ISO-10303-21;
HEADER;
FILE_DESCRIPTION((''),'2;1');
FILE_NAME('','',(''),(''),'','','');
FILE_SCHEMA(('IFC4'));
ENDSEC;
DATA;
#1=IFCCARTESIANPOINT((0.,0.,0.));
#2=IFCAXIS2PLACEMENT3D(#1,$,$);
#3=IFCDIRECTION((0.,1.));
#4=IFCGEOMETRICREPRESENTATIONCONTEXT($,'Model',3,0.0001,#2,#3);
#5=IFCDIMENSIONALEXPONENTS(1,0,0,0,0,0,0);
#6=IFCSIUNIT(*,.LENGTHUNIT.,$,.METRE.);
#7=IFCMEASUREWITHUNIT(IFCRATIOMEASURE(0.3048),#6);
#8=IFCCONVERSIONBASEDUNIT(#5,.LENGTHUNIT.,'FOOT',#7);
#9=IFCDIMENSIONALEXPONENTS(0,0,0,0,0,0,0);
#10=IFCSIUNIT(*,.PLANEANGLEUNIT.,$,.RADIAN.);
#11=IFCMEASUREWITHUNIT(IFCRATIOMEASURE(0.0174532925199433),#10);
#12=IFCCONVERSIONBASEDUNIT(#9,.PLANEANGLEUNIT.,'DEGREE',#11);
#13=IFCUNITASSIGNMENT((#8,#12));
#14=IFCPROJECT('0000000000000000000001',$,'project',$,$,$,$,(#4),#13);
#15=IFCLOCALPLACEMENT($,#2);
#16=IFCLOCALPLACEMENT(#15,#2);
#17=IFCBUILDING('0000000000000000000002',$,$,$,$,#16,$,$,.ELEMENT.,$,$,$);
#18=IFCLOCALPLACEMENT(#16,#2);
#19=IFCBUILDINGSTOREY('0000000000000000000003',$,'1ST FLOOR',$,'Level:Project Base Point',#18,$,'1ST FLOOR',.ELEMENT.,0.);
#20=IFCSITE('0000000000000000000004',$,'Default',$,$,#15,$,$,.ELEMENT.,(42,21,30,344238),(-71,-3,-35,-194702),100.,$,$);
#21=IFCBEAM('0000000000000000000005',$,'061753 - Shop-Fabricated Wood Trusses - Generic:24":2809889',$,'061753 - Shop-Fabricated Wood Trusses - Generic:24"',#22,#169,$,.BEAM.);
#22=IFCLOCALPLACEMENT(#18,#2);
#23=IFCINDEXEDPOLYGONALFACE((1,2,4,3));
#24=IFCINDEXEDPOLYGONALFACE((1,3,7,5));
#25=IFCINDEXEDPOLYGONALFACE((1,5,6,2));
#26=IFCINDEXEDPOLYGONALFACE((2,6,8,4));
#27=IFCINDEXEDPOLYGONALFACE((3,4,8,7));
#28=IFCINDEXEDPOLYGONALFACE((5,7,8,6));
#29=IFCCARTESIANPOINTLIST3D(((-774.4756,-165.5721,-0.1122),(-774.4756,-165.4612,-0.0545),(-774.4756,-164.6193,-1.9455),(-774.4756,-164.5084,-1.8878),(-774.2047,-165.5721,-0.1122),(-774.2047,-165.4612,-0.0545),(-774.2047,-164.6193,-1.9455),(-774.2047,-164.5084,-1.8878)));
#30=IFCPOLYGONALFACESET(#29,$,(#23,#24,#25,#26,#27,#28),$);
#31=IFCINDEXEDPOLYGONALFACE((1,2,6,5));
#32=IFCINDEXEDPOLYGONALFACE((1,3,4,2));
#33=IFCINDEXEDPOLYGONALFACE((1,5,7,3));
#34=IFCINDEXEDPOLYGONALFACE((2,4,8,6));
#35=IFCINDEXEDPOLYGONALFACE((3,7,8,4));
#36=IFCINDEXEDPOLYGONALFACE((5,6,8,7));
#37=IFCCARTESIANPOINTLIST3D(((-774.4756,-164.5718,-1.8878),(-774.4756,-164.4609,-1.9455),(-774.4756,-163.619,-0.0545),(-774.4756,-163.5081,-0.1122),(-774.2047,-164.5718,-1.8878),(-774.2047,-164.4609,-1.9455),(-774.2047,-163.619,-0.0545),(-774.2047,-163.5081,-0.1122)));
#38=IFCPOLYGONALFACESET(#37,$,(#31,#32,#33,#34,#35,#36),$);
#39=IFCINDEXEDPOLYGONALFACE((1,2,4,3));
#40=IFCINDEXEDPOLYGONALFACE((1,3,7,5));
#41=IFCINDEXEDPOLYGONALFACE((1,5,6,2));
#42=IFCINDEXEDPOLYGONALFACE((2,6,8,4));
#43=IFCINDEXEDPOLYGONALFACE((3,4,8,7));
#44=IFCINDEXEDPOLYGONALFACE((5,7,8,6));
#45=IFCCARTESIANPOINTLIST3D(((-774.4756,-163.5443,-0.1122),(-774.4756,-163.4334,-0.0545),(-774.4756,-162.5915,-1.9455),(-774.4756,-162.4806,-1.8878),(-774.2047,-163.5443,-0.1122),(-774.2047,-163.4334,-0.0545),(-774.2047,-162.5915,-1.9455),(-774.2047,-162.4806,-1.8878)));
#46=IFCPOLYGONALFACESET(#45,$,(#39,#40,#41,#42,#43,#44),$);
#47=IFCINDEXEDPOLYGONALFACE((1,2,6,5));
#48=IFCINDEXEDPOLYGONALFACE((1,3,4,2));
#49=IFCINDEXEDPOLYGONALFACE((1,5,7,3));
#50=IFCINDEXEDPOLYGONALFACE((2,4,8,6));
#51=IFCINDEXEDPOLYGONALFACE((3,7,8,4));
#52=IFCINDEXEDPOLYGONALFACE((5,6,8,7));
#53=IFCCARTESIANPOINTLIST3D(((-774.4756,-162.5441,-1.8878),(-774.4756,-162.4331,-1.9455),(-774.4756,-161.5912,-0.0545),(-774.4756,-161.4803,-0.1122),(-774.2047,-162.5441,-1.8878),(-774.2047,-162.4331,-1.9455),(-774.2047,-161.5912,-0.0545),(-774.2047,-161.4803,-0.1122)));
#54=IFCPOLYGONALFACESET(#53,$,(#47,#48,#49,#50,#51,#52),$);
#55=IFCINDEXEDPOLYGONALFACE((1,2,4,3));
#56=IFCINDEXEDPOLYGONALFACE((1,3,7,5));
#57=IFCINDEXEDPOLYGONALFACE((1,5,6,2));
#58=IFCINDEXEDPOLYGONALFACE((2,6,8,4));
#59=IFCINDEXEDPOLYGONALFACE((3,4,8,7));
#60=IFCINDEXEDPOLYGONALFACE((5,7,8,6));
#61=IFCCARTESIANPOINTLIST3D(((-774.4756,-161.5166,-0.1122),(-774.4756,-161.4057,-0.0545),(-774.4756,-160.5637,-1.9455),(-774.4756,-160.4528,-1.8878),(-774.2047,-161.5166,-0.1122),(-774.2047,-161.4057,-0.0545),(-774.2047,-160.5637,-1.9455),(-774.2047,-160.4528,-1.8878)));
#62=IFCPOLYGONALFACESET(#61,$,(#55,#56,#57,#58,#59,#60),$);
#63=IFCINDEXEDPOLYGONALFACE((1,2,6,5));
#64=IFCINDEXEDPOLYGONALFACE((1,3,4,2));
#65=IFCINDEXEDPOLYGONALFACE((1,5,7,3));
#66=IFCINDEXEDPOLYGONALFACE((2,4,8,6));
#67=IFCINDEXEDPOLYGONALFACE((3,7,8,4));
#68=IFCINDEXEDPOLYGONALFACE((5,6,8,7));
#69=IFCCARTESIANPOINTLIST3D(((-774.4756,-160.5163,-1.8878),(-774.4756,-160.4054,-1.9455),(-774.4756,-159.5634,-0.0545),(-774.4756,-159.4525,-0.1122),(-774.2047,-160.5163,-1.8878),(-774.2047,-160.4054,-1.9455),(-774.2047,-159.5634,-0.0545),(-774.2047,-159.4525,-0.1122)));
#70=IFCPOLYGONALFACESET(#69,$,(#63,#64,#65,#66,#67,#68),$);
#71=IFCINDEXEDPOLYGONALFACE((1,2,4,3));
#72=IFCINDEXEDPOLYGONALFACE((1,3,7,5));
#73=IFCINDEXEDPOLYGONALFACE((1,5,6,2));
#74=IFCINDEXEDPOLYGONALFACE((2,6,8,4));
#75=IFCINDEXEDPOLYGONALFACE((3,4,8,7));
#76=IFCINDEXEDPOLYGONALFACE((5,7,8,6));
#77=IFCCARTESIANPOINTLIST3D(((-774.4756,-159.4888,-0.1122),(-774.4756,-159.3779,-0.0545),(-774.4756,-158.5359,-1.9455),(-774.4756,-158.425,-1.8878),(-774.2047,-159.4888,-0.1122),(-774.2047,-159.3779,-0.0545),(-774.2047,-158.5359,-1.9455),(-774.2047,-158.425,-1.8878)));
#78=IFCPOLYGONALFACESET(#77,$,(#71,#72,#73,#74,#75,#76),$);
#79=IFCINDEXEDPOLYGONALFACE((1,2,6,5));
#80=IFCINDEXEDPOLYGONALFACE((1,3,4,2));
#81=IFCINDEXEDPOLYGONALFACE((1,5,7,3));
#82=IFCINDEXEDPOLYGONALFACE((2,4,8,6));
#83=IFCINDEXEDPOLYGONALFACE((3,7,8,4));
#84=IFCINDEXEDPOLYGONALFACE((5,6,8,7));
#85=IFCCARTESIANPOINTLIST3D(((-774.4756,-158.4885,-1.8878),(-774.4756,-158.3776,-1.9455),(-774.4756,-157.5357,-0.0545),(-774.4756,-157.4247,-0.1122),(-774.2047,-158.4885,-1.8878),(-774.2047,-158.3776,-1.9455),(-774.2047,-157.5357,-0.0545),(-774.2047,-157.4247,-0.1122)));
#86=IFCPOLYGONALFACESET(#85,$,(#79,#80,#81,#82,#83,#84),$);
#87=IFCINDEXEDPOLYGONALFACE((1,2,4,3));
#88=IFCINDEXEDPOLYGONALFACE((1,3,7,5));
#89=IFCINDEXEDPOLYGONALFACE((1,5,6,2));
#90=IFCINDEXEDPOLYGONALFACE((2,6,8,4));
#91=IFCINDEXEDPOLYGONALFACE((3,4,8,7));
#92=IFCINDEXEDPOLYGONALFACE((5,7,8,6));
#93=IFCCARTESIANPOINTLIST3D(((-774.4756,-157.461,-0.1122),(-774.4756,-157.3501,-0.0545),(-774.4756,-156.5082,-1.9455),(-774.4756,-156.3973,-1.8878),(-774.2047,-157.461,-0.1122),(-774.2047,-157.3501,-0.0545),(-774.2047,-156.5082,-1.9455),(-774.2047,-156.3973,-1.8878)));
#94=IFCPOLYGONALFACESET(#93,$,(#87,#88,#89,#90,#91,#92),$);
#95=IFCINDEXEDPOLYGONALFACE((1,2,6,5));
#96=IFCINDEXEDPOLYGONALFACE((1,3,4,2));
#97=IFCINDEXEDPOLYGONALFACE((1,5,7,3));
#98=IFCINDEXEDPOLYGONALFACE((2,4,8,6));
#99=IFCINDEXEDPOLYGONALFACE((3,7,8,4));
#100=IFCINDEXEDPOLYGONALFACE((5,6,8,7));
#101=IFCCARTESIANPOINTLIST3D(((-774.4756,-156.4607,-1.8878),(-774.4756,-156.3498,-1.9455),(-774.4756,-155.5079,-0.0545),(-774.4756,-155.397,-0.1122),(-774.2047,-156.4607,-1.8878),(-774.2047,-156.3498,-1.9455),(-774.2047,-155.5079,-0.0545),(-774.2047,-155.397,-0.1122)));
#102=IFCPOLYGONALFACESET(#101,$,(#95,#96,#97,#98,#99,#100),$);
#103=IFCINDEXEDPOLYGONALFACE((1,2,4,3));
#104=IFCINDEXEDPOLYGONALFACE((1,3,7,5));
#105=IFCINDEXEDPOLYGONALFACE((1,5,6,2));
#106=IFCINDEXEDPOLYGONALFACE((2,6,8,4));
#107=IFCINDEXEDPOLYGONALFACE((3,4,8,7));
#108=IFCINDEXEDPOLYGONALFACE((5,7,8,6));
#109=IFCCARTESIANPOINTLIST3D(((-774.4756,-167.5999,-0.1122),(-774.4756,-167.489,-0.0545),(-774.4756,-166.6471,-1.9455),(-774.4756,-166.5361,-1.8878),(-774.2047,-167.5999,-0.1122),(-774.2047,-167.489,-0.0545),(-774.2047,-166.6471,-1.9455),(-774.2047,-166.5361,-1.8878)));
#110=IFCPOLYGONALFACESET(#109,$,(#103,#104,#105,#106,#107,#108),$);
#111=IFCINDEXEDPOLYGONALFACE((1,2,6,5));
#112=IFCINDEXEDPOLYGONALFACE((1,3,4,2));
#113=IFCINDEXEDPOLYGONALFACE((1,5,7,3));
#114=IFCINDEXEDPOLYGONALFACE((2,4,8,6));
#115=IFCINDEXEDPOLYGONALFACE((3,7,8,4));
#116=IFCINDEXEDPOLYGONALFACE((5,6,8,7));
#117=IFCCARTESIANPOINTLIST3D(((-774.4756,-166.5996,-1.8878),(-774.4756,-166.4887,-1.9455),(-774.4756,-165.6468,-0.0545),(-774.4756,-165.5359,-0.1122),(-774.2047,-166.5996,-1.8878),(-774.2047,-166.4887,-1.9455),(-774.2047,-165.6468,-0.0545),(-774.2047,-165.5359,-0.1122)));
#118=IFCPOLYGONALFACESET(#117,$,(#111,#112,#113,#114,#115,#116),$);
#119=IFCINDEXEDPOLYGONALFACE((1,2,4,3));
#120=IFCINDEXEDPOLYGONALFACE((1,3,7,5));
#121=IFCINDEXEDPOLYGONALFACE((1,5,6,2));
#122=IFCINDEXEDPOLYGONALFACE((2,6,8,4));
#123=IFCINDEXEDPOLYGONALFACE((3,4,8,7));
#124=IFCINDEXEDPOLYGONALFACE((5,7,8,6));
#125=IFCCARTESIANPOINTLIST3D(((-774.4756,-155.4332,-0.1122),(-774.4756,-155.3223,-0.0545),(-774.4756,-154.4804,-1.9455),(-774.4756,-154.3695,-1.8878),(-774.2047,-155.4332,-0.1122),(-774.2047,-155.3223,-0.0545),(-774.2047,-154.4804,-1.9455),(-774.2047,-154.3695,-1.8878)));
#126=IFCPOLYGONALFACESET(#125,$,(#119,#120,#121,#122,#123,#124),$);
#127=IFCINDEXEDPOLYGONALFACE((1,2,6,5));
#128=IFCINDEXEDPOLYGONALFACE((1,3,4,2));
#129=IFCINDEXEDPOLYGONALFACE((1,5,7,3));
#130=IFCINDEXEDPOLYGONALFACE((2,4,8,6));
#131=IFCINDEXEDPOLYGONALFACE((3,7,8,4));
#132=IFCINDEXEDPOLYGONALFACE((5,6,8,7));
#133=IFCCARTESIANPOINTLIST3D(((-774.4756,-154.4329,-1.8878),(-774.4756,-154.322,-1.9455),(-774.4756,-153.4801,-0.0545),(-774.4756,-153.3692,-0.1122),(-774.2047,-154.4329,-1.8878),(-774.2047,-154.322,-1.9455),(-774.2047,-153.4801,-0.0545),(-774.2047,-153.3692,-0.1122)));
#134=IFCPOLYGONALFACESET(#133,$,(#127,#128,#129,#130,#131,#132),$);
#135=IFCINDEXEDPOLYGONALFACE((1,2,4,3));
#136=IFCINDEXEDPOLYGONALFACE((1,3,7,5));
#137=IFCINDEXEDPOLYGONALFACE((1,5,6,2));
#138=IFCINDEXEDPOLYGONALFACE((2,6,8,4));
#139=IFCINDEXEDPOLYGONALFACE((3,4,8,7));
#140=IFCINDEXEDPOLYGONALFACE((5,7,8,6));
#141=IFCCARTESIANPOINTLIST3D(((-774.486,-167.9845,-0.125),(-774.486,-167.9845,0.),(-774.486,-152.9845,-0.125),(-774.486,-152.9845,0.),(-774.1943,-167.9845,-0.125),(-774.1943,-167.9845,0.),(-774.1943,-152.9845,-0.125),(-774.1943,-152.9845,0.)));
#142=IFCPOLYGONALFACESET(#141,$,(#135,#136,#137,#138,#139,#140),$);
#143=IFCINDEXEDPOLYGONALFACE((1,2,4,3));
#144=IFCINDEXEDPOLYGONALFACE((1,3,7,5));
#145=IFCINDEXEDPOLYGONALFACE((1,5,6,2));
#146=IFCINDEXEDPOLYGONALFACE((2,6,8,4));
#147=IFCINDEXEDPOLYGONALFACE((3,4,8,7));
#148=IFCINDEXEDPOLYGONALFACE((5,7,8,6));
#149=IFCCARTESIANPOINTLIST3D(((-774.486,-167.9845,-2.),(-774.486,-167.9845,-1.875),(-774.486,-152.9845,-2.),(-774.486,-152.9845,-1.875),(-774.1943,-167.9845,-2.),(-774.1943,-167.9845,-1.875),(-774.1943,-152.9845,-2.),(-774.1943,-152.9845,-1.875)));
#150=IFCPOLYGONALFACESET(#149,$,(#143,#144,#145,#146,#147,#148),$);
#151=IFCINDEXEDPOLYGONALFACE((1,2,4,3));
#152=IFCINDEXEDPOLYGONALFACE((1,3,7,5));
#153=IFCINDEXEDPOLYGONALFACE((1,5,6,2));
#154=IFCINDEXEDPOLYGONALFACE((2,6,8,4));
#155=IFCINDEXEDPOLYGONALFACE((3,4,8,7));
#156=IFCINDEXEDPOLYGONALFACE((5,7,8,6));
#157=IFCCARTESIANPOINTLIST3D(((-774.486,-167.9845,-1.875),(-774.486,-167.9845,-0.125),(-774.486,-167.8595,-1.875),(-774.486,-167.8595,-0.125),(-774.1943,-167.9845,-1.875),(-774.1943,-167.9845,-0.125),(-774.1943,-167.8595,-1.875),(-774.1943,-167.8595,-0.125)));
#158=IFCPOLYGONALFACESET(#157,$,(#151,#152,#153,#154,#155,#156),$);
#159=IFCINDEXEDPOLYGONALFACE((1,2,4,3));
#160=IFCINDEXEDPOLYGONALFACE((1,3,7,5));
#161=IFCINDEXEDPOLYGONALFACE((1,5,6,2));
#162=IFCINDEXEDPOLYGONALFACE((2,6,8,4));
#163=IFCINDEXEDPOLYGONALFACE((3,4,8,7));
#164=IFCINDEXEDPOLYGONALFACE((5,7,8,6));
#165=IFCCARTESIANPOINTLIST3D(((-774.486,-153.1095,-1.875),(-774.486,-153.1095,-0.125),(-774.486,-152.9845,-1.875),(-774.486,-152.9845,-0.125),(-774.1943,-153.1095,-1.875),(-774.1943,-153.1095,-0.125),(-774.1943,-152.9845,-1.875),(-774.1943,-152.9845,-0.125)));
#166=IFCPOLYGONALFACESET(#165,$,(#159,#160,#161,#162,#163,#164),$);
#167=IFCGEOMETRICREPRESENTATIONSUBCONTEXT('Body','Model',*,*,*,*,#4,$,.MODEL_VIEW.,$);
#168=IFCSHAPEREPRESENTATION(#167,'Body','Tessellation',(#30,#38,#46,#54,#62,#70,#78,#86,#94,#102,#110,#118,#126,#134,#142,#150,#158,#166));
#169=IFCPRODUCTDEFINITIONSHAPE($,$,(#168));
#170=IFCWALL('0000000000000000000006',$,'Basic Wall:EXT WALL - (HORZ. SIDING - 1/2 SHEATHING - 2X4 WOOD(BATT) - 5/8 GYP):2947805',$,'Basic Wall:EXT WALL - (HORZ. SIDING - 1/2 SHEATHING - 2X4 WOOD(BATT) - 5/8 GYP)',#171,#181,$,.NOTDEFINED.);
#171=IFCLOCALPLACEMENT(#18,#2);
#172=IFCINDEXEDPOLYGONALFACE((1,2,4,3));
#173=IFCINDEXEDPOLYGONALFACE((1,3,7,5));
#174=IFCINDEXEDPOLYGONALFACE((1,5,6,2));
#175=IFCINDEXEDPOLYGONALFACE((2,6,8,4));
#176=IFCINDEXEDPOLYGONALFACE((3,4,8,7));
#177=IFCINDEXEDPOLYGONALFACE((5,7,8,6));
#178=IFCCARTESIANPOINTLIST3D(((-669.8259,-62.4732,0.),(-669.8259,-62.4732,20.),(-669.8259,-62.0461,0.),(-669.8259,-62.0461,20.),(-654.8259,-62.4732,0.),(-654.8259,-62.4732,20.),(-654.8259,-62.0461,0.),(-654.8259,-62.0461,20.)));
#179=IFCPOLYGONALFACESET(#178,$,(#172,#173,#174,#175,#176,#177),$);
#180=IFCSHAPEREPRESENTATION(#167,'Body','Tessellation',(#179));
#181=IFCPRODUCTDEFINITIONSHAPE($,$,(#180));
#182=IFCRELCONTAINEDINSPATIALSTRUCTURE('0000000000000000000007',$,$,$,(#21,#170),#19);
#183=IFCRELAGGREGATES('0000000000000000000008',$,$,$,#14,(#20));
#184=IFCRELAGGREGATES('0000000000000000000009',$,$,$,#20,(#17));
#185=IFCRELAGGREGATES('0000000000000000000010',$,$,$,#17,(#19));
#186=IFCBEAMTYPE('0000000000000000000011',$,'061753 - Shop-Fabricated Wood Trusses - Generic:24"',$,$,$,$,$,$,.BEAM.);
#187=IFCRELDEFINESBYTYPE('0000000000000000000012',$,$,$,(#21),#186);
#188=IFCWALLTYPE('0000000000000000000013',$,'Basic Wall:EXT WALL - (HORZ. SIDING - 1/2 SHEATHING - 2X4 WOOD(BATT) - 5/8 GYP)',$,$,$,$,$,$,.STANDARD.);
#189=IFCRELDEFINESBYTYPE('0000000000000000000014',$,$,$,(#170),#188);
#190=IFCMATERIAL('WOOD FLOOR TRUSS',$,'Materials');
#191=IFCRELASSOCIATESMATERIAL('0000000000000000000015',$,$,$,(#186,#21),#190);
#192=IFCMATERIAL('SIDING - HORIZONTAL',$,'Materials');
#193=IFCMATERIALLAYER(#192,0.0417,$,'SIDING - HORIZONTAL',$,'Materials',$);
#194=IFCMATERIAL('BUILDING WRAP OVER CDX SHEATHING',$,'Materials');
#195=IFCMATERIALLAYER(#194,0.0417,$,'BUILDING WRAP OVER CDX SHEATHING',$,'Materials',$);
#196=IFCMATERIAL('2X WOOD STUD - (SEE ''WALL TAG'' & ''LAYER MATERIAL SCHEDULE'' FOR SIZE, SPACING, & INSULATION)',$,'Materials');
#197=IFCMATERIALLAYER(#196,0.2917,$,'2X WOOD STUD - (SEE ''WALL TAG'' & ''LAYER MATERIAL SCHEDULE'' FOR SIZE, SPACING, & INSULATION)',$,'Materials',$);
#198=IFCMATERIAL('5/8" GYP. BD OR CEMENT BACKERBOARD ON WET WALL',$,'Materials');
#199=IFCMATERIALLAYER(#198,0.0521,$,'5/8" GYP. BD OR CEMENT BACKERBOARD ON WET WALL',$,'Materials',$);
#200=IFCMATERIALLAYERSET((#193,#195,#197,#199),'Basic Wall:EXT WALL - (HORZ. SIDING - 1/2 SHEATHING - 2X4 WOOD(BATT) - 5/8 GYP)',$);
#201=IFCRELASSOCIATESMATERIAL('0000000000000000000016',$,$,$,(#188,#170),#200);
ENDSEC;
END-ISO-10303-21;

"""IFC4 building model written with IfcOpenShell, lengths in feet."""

from ifc_helpers import new_model, entity, si_unit, converted_unit, direction, frame, frame_2d, origin, origin_2d_with_axis, place, context, subcontext, project, spatial, rectangle, extrude, source, transform, mapped, material, layer, layer_set, layer_usage, material_profile, profile_set, profile_usage, type_object, type_shapes, element, save


model = new_model("IFC4")

# Units and contexts
model_context = context("Model", 3, precision=0.0001, world=origin(), true_north=direction((0.0, 1.0)))
body_context = subcontext(model_context, "Body", "Model", "MODEL_VIEW")
ifc_project = project(units=[converted_unit("LENGTHUNIT", "FOOT", entity("IfcRatioMeasure", 0.3048), si_unit("LENGTHUNIT", "METRE"), dimensions=[1, 0, 0, 0, 0, 0, 0]), converted_unit("PLANEANGLEUNIT", "DEGREE", entity("IfcRatioMeasure", 0.0174532925199433), si_unit("PLANEANGLEUNIT", "RADIAN"), dimensions=[0, 0, 0, 0, 0, 0, 0])], contexts=[model_context])

# Site, building, storey
site_placement = place(None, origin())
site = spatial("IfcSite", under=ifc_project, at=site_placement, Name="Default", CompositionType="ELEMENT", RefLatitude=(42, 21, 30, 344238), RefLongitude=(-71, -3, -35, -194702), RefElevation=100.0)
building_placement = place(site_placement, origin())
building = spatial("IfcBuilding", under=site, at=building_placement, CompositionType="ELEMENT")
storey_placement = place(building_placement, origin())
storey = spatial("IfcBuildingStorey", under=building, at=storey_placement, Name="1ST FLOOR", ObjectType="Level:Project Base Point", LongName="1ST FLOOR", CompositionType="ELEMENT", Elevation=0.0)

# Beam
ifc_material_1 = material(Name="WOOD FLOOR TRUSS", Category="Materials")
ifc_material_profile_1 = material_profile(ifc_material_1, rectangle(XDim=2.0662, YDim=0.125, at=origin_2d_with_axis()), Name="24\"")
ifc_material_profile_2 = material_profile(ifc_material_1, rectangle(XDim=2.0662, YDim=0.125, at=frame_2d((0.0, 0.0), x_axis=(1.0, 0.0))), Name="24\"")
ifc_material_profile_3 = material_profile(ifc_material_1, rectangle(XDim=2.0662, YDim=0.125, at=frame_2d((0.0, 0.0), x_axis=(1.0, 0.0))), Name="24\"")
ifc_material_profile_4 = material_profile(ifc_material_1, rectangle(XDim=2.0662, YDim=0.125, at=origin_2d_with_axis()), Name="24\"")
ifc_material_profile_5 = material_profile(ifc_material_1, rectangle(XDim=2.0662, YDim=0.125, at=origin_2d_with_axis()), Name="24\"")
ifc_material_profile_6 = material_profile(ifc_material_1, rectangle(XDim=2.0662, YDim=0.125, at=frame_2d((0.0, 0.0), x_axis=(1.0, 0.0))), Name="24\"")
ifc_material_profile_7 = material_profile(ifc_material_1, rectangle(XDim=2.0662, YDim=0.125, at=origin_2d_with_axis()), Name="24\"")
ifc_material_profile_8 = material_profile(ifc_material_1, rectangle(XDim=2.0662, YDim=0.125, at=frame_2d((0.0, 0.0), x_axis=(1.0, 0.0))), Name="24\"")
ifc_material_profile_9 = material_profile(ifc_material_1, rectangle(XDim=2.0662, YDim=0.125, at=origin_2d_with_axis()), Name="24\"")
ifc_material_profile_10 = material_profile(ifc_material_1, rectangle(XDim=2.0662, YDim=0.125, at=frame_2d((0.0, 0.0), x_axis=(1.0, 0.0))), Name="24\"")
ifc_material_profile_11 = material_profile(ifc_material_1, rectangle(XDim=2.0662, YDim=0.125, at=origin_2d_with_axis()), Name="24\"")
ifc_material_profile_12 = material_profile(ifc_material_1, rectangle(XDim=2.0662, YDim=0.125, at=frame_2d((0.0, 0.0), x_axis=(1.0, 0.0))), Name="24\"")
ifc_material_profile_13 = material_profile(ifc_material_1, rectangle(XDim=2.0662, YDim=0.125, at=origin_2d_with_axis()), Name="24\"")
ifc_material_profile_14 = material_profile(ifc_material_1, rectangle(XDim=2.0662, YDim=0.125, at=frame_2d((0.0, 0.0), x_axis=(1.0, 0.0))), Name="24\"")
ifc_material_profile_15 = material_profile(ifc_material_1, rectangle(XDim=0.125, YDim=0.2917, at=origin_2d_with_axis()), Name="24\"")
ifc_material_profile_16 = material_profile(ifc_material_1, rectangle(XDim=0.125, YDim=0.2917, at=origin_2d_with_axis()), Name="24\"")
ifc_material_profile_17 = material_profile(ifc_material_1, rectangle(XDim=1.75, YDim=0.2917, at=origin_2d_with_axis()), Name="24\"")
ifc_material_profile_18 = material_profile(ifc_material_1, rectangle(XDim=1.75, YDim=0.2917, at=origin_2d_with_axis()), Name="24\"")
ifc_profile_set_1 = profile_set([ifc_material_profile_1, ifc_material_profile_2, ifc_material_profile_3, ifc_material_profile_4, ifc_material_profile_5, ifc_material_profile_6, ifc_material_profile_7, ifc_material_profile_8, ifc_material_profile_9, ifc_material_profile_10, ifc_material_profile_11, ifc_material_profile_12, ifc_material_profile_13, ifc_material_profile_14, ifc_material_profile_15, ifc_material_profile_16, ifc_material_profile_17, ifc_material_profile_18], Name="24\"")
ifc_profile_usage_1 = profile_usage(ifc_profile_set_1, cardinal=8)
beam_type_1 = type_object("IfcBeamType", Name="061753 - Shop-Fabricated Wood Trusses - Generic:24\"", PredefinedType="BEAM", material=ifc_profile_set_1)
shared_shape_1 = source(origin(), body_context, "Body", "SweptSolid", [
    extrude(rectangle(XDim=2.0662, YDim=0.125, at=origin_2d_with_axis()), frame((4.5557, -0.1354, 0.0), z_axis=(0.0, 1.0, 0.0), x_axis=(0.461164, 0.0, 0.887315)), (0.0, 0.0, 1.0), 0.2708),
    extrude(rectangle(XDim=2.0662, YDim=0.125, at=frame_2d((0.0, 0.0), x_axis=(1.0, 0.0))), frame((3.5554, -0.1354, 0.0), z_axis=(0.0, 1.0, 0.0), x_axis=(0.461164, 0.0, -0.887315)), (0.0, 0.0, 1.0), 0.2708),
    extrude(rectangle(XDim=2.0662, YDim=0.125, at=frame_2d((0.0, 0.0), x_axis=(1.0, 0.0))), frame((2.5279, -0.1354, 0.0), z_axis=(0.0, 1.0, 0.0), x_axis=(0.461164, 0.0, 0.887315)), (0.0, 0.0, 1.0), 0.2708),
    extrude(rectangle(XDim=2.0662, YDim=0.125, at=origin_2d_with_axis()), frame((1.5276, -0.1354, 0.0), z_axis=(0.0, 1.0, 0.0), x_axis=(0.461164, 0.0, -0.887315)), (0.0, 0.0, 1.0), 0.2708),
    extrude(rectangle(XDim=2.0662, YDim=0.125, at=origin_2d_with_axis()), frame((0.5001, -0.1354, 0.0), z_axis=(0.0, 1.0, 0.0), x_axis=(0.461164, 0.0, 0.887315)), (0.0, 0.0, 1.0), 0.2708),
    extrude(rectangle(XDim=2.0662, YDim=0.125, at=frame_2d((0.0, 0.0), x_axis=(1.0, 0.0))), frame((-0.5001, -0.1354, 0.0), z_axis=(0.0, 1.0, 0.0), x_axis=(0.461164, 0.0, -0.887315)), (0.0, 0.0, 1.0), 0.2708),
    extrude(rectangle(XDim=2.0662, YDim=0.125, at=origin_2d_with_axis()), frame((-1.5276, -0.1354, 0.0), z_axis=(0.0, 1.0, 0.0), x_axis=(0.461164, 0.0, 0.887315)), (0.0, 0.0, 1.0), 0.2708),
    extrude(rectangle(XDim=2.0662, YDim=0.125, at=frame_2d((0.0, 0.0), x_axis=(1.0, 0.0))), frame((-2.5279, -0.1354, 0.0), z_axis=(0.0, 1.0, 0.0), x_axis=(0.461164, 0.0, -0.887315)), (0.0, 0.0, 1.0), 0.2708),
    extrude(rectangle(XDim=2.0662, YDim=0.125, at=origin_2d_with_axis()), frame((-3.5554, -0.1354, 0.0), z_axis=(0.0, 1.0, 0.0), x_axis=(0.461164, 0.0, 0.887315)), (0.0, 0.0, 1.0), 0.2708),
    extrude(rectangle(XDim=2.0662, YDim=0.125, at=frame_2d((0.0, 0.0), x_axis=(1.0, 0.0))), frame((-4.5557, -0.1354, 0.0), z_axis=(0.0, 1.0, 0.0), x_axis=(0.461164, 0.0, -0.887315)), (0.0, 0.0, 1.0), 0.2708),
    extrude(rectangle(XDim=2.0662, YDim=0.125, at=origin_2d_with_axis()), frame((6.5835, -0.1354, 0.0), z_axis=(0.0, 1.0, 0.0), x_axis=(0.461164, 0.0, 0.887315)), (0.0, 0.0, 1.0), 0.2708),
    extrude(rectangle(XDim=2.0662, YDim=0.125, at=frame_2d((0.0, 0.0), x_axis=(1.0, 0.0))), frame((5.5832, -0.1354, 0.0), z_axis=(0.0, 1.0, 0.0), x_axis=(0.461164, 0.0, -0.887315)), (0.0, 0.0, 1.0), 0.2708),
    extrude(rectangle(XDim=2.0662, YDim=0.125, at=origin_2d_with_axis()), frame((-5.5832, -0.1354, 0.0), z_axis=(0.0, 1.0, 0.0), x_axis=(0.461164, 0.0, 0.887315)), (0.0, 0.0, 1.0), 0.2708),
    extrude(rectangle(XDim=2.0662, YDim=0.125, at=frame_2d((0.0, 0.0), x_axis=(1.0, 0.0))), frame((-6.5835, -0.1354, 0.0), z_axis=(0.0, 1.0, 0.0), x_axis=(0.461164, 0.0, -0.887315)), (0.0, 0.0, 1.0), 0.2708),
    extrude(rectangle(XDim=0.125, YDim=0.2917, at=origin_2d_with_axis()), frame((-7.5, 0.0, 0.9375), z_axis=(1.0, 0.0, 0.0), x_axis=(0.0, 0.0, -1.0)), (0.0, 0.0, 1.0), 15.0),
    extrude(rectangle(XDim=0.125, YDim=0.2917, at=origin_2d_with_axis()), frame((-7.5, 0.0, -0.9375), z_axis=(1.0, 0.0, 0.0), x_axis=(0.0, 0.0, -1.0)), (0.0, 0.0, 1.0), 15.0),
    extrude(rectangle(XDim=1.75, YDim=0.2917, at=origin_2d_with_axis()), frame((7.375, 0.0, 0.0), z_axis=(1.0, 0.0, 0.0), x_axis=(0.0, 0.0, -1.0)), (0.0, 0.0, 1.0), 0.125),
    extrude(rectangle(XDim=1.75, YDim=0.2917, at=origin_2d_with_axis()), frame((-7.5, 0.0, 0.0), z_axis=(1.0, 0.0, 0.0), x_axis=(0.0, 0.0, -1.0)), (0.0, 0.0, 1.0), 0.125),
])
type_shapes(beam_type_1, [shared_shape_1])
beam_1_placement = place(storey_placement, frame((-774.3401, -160.4845, -1.0), z_axis=(0.0, 0.0, 1.0), x_axis=(0.0, -1.0, 0.0)))
element("IfcBeam", 1, at=beam_1_placement, inside=storey, type_object=beam_type_1, material=ifc_profile_usage_1, Name="061753 - Shop-Fabricated Wood Trusses - Generic:24\":2809889", ObjectType="061753 - Shop-Fabricated Wood Trusses - Generic:24\"", PredefinedType="BEAM", context=body_context, shape_type="MappedRepresentation", body=[
    mapped(shared_shape_1, transform((0.0, 0.0, 0.0), scale=1.0)),
])

# Wall
ifc_material_2 = material(Name="SIDING - HORIZONTAL", Category="Materials")
ifc_layer_1 = layer(ifc_material_2, 0.0417, Name="SIDING - HORIZONTAL", Category="Materials")
ifc_material_3 = material(Name="BUILDING WRAP OVER CDX SHEATHING", Category="Materials")
ifc_layer_2 = layer(ifc_material_3, 0.0417, Name="BUILDING WRAP OVER CDX SHEATHING", Category="Materials")
ifc_material_4 = material(Name="2X WOOD STUD - (SEE 'WALL TAG' & 'LAYER MATERIAL SCHEDULE' FOR SIZE, SPACING, & INSULATION)", Category="Materials")
ifc_layer_3 = layer(ifc_material_4, 0.2917, Name="2X WOOD STUD - (SEE 'WALL TAG' & 'LAYER MATERIAL SCHEDULE' FOR SIZE, SPACING, & INSULATION)", Category="Materials")
ifc_material_5 = material(Name="5/8\" GYP. BD OR CEMENT BACKERBOARD ON WET WALL", Category="Materials")
ifc_layer_4 = layer(ifc_material_5, 0.0521, Name="5/8\" GYP. BD OR CEMENT BACKERBOARD ON WET WALL", Category="Materials")
ifc_layer_set_1 = layer_set([ifc_layer_1, ifc_layer_2, ifc_layer_3, ifc_layer_4], Name="Basic Wall:EXT WALL - (HORZ. SIDING - 1/2 SHEATHING - 2X4 WOOD(BATT) - 5/8 GYP)")
ifc_layer_usage_1 = layer_usage(ifc_layer_set_1, "AXIS2", "NEGATIVE", 0.2135)
wall_type_1 = type_object("IfcWallType", Name="Basic Wall:EXT WALL - (HORZ. SIDING - 1/2 SHEATHING - 2X4 WOOD(BATT) - 5/8 GYP)", PredefinedType="STANDARD", material=ifc_layer_set_1)
wall_1_placement = place(storey_placement, frame((-669.8259, -62.2596, 0.0)))
element("IfcWall", 2, at=wall_1_placement, inside=storey, type_object=wall_type_1, material=ifc_layer_usage_1, Name="Basic Wall:EXT WALL - (HORZ. SIDING - 1/2 SHEATHING - 2X4 WOOD(BATT) - 5/8 GYP):2947805", ObjectType="Basic Wall:EXT WALL - (HORZ. SIDING - 1/2 SHEATHING - 2X4 WOOD(BATT) - 5/8 GYP)", PredefinedType="NOTDEFINED", context=body_context, shape_type="SweptSolid", body=[
    extrude(rectangle(XDim=15.0, YDim=0.4271, at=frame_2d((7.5, 0.0), x_axis=(-1.0, 0.0))), origin(), (0.0, 0.0, 1.0), 20.0),
])

save(model, "model.ifc")
